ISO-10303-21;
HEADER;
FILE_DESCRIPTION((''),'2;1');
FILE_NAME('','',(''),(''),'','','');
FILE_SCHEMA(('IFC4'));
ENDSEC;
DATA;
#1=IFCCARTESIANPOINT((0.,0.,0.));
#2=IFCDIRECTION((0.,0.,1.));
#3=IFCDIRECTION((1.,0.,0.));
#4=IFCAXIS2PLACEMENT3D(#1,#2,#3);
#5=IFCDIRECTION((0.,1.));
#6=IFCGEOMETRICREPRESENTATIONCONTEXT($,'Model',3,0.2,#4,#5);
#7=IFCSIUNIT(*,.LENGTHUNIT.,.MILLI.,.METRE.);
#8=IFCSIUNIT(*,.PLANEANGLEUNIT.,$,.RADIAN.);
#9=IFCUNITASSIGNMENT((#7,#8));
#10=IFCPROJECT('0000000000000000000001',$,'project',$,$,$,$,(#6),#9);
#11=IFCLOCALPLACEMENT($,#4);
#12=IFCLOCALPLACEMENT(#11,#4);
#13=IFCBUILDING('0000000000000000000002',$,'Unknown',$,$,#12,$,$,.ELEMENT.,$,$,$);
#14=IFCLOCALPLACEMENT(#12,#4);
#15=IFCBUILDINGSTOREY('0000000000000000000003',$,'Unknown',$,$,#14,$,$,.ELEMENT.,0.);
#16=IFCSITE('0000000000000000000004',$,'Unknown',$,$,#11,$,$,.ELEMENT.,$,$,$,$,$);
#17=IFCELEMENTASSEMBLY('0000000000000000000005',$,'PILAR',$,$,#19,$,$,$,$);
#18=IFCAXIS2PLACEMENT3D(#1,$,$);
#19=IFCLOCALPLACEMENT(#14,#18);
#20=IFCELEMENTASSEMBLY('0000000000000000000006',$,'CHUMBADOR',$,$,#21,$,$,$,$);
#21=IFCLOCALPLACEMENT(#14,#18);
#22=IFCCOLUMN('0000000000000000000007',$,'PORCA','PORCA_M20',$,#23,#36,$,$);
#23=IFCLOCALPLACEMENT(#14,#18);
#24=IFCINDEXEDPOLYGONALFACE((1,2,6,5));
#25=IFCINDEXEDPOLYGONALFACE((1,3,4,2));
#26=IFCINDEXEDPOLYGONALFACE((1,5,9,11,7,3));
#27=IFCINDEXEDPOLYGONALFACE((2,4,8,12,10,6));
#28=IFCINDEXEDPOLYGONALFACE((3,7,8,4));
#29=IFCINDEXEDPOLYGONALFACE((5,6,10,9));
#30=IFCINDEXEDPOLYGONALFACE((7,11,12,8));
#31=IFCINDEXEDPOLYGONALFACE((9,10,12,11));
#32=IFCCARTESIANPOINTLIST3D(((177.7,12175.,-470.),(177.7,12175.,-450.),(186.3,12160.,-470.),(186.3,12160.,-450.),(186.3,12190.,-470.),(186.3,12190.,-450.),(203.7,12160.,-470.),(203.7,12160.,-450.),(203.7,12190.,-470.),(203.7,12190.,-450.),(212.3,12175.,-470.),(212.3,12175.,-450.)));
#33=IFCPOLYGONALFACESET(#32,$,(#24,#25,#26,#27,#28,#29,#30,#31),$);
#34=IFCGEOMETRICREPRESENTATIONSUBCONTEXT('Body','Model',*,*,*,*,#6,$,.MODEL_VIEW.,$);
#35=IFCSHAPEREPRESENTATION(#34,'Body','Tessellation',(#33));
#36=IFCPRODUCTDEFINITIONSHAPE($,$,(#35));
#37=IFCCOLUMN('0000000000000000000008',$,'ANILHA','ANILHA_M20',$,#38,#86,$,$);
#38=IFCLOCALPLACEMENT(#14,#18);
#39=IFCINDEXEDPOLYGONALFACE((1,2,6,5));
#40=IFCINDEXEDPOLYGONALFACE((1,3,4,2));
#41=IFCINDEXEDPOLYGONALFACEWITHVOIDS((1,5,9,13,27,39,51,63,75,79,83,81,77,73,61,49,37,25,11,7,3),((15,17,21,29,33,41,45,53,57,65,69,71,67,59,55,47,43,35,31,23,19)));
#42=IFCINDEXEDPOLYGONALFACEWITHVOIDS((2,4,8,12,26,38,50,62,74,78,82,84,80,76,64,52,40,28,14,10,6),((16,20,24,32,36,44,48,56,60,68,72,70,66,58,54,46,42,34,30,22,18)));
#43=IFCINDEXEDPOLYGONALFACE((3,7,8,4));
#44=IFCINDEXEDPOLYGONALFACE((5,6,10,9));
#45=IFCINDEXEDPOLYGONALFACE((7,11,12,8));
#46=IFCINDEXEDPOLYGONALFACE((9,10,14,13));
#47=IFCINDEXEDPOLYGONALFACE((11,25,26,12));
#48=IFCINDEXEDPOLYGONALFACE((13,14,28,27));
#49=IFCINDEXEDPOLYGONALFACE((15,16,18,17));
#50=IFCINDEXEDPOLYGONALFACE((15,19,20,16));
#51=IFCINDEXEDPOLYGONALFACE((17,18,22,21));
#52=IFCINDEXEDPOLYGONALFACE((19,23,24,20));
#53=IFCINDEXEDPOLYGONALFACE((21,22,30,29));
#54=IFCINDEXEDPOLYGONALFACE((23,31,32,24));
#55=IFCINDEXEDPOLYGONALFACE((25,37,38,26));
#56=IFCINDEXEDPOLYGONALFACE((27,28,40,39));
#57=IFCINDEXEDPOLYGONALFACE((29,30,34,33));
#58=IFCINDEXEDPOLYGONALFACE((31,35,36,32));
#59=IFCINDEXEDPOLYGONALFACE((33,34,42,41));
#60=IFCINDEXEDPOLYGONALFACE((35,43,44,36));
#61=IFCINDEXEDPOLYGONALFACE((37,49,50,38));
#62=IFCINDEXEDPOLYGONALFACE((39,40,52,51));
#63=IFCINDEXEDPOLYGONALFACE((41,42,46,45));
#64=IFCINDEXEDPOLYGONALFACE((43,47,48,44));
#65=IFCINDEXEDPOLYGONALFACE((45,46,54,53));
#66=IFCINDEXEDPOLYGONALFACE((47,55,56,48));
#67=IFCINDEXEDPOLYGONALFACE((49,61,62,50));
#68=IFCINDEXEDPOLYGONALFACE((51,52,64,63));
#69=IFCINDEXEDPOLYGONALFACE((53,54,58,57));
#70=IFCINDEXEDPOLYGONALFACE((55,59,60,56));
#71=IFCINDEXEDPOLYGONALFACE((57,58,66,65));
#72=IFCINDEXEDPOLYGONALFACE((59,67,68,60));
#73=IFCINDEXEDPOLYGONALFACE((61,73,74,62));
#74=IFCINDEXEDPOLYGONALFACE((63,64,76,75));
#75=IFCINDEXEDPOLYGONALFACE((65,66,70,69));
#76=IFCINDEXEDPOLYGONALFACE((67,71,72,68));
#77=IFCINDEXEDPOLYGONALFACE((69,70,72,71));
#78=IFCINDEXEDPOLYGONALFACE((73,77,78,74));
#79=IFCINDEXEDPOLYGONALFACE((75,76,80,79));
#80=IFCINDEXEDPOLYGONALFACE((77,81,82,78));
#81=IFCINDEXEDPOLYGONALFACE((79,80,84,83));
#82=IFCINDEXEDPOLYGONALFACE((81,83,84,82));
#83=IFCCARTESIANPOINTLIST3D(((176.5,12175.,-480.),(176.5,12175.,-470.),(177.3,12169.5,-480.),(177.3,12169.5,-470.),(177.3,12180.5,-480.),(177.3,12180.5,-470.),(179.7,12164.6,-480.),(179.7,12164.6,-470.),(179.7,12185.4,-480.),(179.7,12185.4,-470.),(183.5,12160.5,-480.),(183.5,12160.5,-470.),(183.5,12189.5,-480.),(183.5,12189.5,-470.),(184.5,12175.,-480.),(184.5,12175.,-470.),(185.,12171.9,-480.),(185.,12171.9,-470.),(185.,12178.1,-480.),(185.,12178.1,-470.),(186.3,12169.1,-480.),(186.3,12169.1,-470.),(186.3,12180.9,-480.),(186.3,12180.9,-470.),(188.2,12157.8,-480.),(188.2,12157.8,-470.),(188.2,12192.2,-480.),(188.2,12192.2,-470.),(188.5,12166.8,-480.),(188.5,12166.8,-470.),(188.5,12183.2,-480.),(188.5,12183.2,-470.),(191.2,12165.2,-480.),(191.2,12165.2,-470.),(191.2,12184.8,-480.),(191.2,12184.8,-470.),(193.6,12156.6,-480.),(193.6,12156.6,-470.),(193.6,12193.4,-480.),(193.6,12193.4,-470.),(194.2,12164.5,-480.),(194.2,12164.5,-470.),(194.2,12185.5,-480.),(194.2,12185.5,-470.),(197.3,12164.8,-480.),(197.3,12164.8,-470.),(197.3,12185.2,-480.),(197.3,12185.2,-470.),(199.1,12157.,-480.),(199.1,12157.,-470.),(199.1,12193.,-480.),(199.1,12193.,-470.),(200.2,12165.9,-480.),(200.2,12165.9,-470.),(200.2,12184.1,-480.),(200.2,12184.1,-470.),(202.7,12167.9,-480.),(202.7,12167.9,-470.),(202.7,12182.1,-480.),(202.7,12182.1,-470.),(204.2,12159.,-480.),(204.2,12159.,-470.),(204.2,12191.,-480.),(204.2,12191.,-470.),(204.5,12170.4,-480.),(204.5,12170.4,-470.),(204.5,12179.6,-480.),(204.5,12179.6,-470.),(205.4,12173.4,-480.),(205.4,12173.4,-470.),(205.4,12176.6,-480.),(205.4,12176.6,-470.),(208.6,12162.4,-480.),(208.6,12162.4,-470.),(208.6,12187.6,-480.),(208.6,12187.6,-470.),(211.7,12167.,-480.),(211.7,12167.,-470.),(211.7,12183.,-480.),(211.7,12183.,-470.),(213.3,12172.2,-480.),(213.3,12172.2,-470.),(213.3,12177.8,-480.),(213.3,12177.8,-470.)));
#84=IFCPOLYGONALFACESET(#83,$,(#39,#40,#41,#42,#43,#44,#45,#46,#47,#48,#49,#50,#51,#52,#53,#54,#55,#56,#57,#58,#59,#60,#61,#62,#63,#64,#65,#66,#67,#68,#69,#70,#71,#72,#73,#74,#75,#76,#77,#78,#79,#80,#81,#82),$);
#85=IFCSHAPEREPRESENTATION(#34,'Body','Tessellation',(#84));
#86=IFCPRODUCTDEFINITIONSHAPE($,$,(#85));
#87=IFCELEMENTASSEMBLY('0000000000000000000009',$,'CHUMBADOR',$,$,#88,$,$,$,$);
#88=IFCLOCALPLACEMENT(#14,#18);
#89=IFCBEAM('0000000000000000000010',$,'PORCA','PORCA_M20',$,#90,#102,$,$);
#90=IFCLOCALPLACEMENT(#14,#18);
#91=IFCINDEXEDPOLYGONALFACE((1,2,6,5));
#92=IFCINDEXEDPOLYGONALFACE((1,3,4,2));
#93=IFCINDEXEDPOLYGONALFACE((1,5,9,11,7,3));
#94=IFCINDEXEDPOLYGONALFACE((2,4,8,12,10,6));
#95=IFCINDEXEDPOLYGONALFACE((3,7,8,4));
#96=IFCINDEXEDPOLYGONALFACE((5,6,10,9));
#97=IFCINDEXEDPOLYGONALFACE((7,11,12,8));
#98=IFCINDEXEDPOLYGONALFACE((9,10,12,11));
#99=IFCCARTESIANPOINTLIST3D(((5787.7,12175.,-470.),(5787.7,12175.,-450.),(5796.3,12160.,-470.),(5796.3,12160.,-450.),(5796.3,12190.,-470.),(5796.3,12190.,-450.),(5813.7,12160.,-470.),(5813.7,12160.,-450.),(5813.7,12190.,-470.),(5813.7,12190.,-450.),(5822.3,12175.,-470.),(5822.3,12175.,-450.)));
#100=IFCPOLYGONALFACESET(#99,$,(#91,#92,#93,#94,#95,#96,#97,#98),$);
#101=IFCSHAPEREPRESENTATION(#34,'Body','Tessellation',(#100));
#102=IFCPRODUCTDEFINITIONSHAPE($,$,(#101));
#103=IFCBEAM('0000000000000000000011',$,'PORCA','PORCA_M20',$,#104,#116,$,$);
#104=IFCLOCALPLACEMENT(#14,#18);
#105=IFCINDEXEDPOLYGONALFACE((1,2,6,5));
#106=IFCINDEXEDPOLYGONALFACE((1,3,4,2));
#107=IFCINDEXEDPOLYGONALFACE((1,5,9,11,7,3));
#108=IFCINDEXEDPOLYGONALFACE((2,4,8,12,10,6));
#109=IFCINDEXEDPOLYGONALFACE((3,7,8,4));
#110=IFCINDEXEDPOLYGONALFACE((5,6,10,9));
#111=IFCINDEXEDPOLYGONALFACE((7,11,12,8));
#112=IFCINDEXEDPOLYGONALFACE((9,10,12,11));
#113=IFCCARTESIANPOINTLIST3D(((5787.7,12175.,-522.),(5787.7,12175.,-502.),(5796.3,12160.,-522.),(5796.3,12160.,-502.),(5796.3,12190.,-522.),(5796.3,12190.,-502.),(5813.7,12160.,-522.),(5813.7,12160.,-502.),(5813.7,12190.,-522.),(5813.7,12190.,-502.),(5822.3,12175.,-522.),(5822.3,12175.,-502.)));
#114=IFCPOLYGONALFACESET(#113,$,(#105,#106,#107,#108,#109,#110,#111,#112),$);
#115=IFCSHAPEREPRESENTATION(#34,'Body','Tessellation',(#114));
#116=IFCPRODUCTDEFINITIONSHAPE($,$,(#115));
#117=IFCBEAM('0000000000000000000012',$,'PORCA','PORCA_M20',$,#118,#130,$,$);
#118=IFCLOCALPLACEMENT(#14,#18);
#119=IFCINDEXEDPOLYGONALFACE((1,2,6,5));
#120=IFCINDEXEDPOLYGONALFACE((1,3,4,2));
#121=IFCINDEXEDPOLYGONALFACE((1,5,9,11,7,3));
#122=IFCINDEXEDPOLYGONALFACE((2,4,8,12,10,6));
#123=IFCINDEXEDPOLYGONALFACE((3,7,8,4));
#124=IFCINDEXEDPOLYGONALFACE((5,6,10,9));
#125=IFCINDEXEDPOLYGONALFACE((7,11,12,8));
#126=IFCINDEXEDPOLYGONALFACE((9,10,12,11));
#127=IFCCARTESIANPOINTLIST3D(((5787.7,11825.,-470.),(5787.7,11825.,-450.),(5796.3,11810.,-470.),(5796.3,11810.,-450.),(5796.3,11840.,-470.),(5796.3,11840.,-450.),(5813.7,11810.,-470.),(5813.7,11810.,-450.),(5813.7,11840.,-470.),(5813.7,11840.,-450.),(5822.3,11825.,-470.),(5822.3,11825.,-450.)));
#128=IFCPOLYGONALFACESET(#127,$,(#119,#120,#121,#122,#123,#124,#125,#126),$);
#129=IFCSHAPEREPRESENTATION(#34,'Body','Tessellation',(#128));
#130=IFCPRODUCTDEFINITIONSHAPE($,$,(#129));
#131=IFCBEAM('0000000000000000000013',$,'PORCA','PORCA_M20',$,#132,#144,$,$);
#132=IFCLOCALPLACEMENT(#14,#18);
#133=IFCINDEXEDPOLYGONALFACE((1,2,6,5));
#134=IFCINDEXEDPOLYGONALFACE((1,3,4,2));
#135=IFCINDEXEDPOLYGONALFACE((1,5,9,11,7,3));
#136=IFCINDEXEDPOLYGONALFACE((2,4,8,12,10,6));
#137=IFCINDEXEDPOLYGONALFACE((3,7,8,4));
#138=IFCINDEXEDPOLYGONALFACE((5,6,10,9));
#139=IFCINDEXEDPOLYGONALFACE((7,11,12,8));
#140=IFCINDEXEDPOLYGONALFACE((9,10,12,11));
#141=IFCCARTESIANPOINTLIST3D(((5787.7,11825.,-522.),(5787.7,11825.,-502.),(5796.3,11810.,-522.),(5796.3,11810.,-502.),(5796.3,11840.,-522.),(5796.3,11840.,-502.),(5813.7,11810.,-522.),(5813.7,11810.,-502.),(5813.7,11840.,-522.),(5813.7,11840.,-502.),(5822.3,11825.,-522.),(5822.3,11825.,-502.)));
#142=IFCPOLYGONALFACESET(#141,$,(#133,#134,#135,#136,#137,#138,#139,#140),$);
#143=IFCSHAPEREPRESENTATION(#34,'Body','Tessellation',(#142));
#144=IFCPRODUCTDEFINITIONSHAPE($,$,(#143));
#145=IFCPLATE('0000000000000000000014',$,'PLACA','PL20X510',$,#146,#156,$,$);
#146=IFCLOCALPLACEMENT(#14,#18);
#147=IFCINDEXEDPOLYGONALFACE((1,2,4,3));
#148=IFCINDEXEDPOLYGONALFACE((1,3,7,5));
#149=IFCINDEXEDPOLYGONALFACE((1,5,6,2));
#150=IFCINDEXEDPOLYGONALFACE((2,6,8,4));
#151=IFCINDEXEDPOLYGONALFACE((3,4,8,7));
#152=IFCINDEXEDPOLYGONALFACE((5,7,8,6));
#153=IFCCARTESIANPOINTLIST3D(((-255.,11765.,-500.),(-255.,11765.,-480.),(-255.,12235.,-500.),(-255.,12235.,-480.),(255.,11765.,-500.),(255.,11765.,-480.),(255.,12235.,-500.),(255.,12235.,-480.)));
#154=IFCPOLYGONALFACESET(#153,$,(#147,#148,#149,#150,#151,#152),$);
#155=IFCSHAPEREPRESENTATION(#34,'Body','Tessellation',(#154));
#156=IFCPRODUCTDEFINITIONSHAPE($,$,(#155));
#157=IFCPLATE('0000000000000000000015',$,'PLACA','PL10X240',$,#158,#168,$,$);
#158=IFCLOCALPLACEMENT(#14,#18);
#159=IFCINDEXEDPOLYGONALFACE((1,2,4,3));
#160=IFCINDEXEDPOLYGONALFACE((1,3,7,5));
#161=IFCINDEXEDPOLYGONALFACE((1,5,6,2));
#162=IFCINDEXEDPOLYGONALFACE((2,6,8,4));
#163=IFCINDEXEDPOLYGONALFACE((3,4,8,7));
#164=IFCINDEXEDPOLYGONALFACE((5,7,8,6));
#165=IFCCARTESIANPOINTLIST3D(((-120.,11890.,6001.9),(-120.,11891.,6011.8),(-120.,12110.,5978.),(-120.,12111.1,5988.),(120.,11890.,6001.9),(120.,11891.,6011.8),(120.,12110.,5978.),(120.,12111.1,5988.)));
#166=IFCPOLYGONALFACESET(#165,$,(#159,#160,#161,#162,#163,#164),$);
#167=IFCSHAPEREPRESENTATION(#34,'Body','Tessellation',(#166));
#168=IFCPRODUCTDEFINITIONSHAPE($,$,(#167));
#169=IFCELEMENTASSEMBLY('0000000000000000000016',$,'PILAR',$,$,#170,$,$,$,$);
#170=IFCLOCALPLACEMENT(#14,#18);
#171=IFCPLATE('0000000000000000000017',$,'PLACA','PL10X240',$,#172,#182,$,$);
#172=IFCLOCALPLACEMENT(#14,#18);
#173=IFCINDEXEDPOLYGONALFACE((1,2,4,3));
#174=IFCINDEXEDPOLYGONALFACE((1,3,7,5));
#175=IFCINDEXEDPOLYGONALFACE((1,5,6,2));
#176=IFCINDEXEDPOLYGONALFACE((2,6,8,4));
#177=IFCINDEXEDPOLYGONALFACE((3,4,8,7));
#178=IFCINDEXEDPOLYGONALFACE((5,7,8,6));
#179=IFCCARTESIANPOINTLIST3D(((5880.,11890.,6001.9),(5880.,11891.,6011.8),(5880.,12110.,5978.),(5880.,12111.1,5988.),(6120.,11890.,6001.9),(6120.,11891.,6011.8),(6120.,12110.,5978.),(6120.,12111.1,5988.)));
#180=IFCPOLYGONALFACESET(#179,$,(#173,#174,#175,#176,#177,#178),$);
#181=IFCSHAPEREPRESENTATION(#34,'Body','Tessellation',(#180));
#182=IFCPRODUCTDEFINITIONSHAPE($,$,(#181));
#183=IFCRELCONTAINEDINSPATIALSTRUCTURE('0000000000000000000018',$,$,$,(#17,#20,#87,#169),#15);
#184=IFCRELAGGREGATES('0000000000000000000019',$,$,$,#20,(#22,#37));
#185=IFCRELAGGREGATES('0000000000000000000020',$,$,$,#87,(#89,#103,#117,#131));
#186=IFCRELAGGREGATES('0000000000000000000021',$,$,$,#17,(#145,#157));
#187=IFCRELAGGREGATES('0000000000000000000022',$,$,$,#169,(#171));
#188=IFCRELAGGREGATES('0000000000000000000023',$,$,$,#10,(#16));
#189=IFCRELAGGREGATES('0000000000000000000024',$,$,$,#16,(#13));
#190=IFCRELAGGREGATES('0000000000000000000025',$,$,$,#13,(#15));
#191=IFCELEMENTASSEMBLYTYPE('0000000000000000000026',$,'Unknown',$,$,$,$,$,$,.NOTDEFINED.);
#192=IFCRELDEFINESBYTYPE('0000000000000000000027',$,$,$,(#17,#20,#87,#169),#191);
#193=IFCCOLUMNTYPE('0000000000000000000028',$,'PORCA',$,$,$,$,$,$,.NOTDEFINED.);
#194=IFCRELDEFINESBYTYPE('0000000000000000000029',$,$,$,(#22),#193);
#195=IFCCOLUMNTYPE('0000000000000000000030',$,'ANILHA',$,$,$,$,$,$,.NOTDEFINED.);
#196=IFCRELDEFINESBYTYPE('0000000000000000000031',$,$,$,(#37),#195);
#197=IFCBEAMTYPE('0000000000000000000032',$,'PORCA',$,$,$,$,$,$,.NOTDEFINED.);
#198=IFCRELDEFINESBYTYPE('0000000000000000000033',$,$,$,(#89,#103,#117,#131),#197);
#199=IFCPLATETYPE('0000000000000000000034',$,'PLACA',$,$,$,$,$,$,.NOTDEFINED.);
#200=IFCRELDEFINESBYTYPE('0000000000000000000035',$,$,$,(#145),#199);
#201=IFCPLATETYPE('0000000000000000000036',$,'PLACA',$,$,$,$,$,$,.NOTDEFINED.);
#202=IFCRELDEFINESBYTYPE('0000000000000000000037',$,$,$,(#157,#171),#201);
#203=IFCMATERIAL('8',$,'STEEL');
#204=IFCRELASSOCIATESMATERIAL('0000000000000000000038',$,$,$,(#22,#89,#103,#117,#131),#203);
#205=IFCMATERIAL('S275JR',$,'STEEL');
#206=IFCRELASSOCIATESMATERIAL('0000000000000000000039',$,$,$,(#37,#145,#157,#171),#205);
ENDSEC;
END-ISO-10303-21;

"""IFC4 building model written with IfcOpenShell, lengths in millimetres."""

from ifc_helpers import new_model, si_unit, direction, frame, origin_with_axes, origin_2d_with_axis, place, context, subcontext, project, spatial, polyline, rectangle, hollow_circle, outline, extrude, material, material_profile, profile_set, profile_usage, type_object, element, aggregate, save


model = new_model("IFC4")

# Units and contexts
model_context = context("Model", 3, precision=0.2, world=origin_with_axes(), true_north=direction((0.0, 1.0)))
body_context = subcontext(model_context, "Body", "Model", "MODEL_VIEW")
ifc_project = project(units=[si_unit("LENGTHUNIT", "METRE", prefix="MILLI"), si_unit("PLANEANGLEUNIT", "RADIAN")], contexts=[model_context])

# Site, building, storey
site_placement = place(None, origin_with_axes())
site = spatial("IfcSite", under=ifc_project, at=site_placement, Name="Unknown", CompositionType="ELEMENT")
building_placement = place(site_placement, origin_with_axes())
building = spatial("IfcBuilding", under=site, at=building_placement, Name="Unknown", CompositionType="ELEMENT")
storey_placement = place(building_placement, origin_with_axes())
storey = spatial("IfcBuildingStorey", under=building, at=storey_placement, Name="Unknown", CompositionType="ELEMENT", Elevation=0.0)

# Shared definitions
element_assembly_type = type_object("IfcElementAssemblyType", Name="Unknown", PredefinedType="NOTDEFINED")

# Element assembly
assembly_1_placement = place(storey_placement, frame((0.0, 12000.0, -500.0), z_axis=(-1.0, 0.0, 0.0), x_axis=(0.0, 0.0, 1.0)))
assembly_1 = element("IfcElementAssembly", 1, at=assembly_1_placement, inside=storey, type_object=element_assembly_type, Name="PILAR")

# Element assembly, columns
assembly_2_placement = place(storey_placement, frame((195.0, 12175.0, -555.0), z_axis=(-1.0, 0.0, 0.0), x_axis=(0.0, 0.0, -1.0)))
assembly_2 = element("IfcElementAssembly", 2, at=assembly_2_placement, inside=storey, type_object=element_assembly_type, Name="CHUMBADOR")
ifc_material_1 = material(Name="8", Category="STEEL")
ifc_material_profile_1 = material_profile(ifc_material_1, outline(polyline([(8.7, -15.0), (17.3, 0.0), (8.7, 15.0), (-8.7, 15.0), (-17.3, 0.0), (-8.7, -15.0), (8.7, -15.0)])), Name="PORCA_M20")
ifc_profile_set_1 = profile_set([ifc_material_profile_1])
ifc_profile_usage_1 = profile_usage(ifc_profile_set_1, cardinal=5)
column_type_1 = type_object("IfcColumnType", Name="PORCA", PredefinedType="NOTDEFINED")
column_1_placement = place(assembly_2_placement, frame((-105.0, 0.0, 0.0), z_axis=(0.0, 0.0, -1.0), x_axis=(1.0, 0.0, 0.0)))
column_1 = element("IfcColumn", 3, at=column_1_placement, type_object=column_type_1, material=ifc_profile_usage_1, Name="PORCA", Description="PORCA_M20", context=body_context, shape_type="SolidModel", body=[
    extrude(outline(polyline([(8.7, -15.0), (17.3, 0.0), (8.7, 15.0), (-8.7, 15.0), (-17.3, 0.0), (-8.7, -15.0), (8.7, -15.0)])), frame((0.0, 0.0, 0.0), z_axis=(-1.0, 0.0, 0.0), x_axis=(0.0, 0.0, 1.0)), (0.0, 0.0, -1.0), 20.0),
])
ifc_material_2 = material(Name="S275JR", Category="STEEL")
ifc_material_profile_2 = material_profile(ifc_material_2, hollow_circle(Radius=18.5, WallThickness=8.0, at=origin_2d_with_axis()), Name="ANILHA_M20")
ifc_profile_set_2 = profile_set([ifc_material_profile_2])
ifc_profile_usage_2 = profile_usage(ifc_profile_set_2, cardinal=5)
column_type_2 = type_object("IfcColumnType", Name="ANILHA", PredefinedType="NOTDEFINED")
column_2_placement = place(assembly_2_placement, frame((-85.0, 0.0, 0.0), z_axis=(0.0, 0.0, 1.0), x_axis=(1.0, 0.0, 0.0)))
column_2 = element("IfcColumn", 4, at=column_2_placement, type_object=column_type_2, material=ifc_profile_usage_2, Name="ANILHA", Description="ANILHA_M20", context=body_context, shape_type="SolidModel", body=[
    extrude(hollow_circle(Radius=18.5, WallThickness=8.0, at=origin_2d_with_axis()), frame((0.0, 0.0, 0.0), z_axis=(-1.0, 0.0, 0.0), x_axis=(0.0, 0.0, 1.0)), (0.0, 0.0, -1.0), 10.0),
])
aggregate(assembly_2, [column_1, column_2])

# Element assembly, beams
assembly_3_placement = place(storey_placement, frame((6195.0, 12175.0, -555.0), z_axis=(-1.0, 0.0, 0.0), x_axis=(0.0, 0.0, -1.0)))
assembly_3 = element("IfcElementAssembly", 5, at=assembly_3_placement, inside=storey, type_object=element_assembly_type, Name="CHUMBADOR")
beam_type_1 = type_object("IfcBeamType", Name="PORCA", PredefinedType="NOTDEFINED")
beam_1_placement = place(assembly_3_placement, frame((-105.0, 0.0, 390.0), z_axis=(0.0, 0.0, 1.0), x_axis=(1.0, 0.0, 0.0)))
beam_1 = element("IfcBeam", 6, at=beam_1_placement, type_object=beam_type_1, material=ifc_profile_usage_1, Name="PORCA", Description="PORCA_M20", context=body_context, shape_type="SolidModel", body=[
    extrude(outline(polyline([(8.7, -15.0), (17.3, 0.0), (8.7, 15.0), (-8.7, 15.0), (-17.3, 0.0), (-8.7, -15.0), (8.7, -15.0)])), frame((0.0, 0.0, 0.0), z_axis=(-1.0, 0.0, 0.0), x_axis=(0.0, 0.0, 1.0)), (0.0, 0.0, -1.0), 20.0),
])
beam_2_placement = place(assembly_3_placement, frame((-53.0, 0.0, 390.0), z_axis=(0.0, 0.0, 1.0), x_axis=(1.0, 0.0, 0.0)))
beam_2 = element("IfcBeam", 7, at=beam_2_placement, type_object=beam_type_1, material=ifc_profile_usage_1, Name="PORCA", Description="PORCA_M20", context=body_context, shape_type="SolidModel", body=[
    extrude(outline(polyline([(8.7, -15.0), (17.3, 0.0), (8.7, 15.0), (-8.7, 15.0), (-17.3, 0.0), (-8.7, -15.0), (8.7, -15.0)])), frame((0.0, 0.0, 0.0), z_axis=(-1.0, 0.0, 0.0), x_axis=(0.0, 0.0, 1.0)), (0.0, 0.0, -1.0), 20.0),
])
beam_3_placement = place(assembly_3_placement, frame((-105.0, 350.0, 390.0), z_axis=(0.0, 0.0, 1.0), x_axis=(1.0, 0.0, 0.0)))
beam_3 = element("IfcBeam", 8, at=beam_3_placement, type_object=beam_type_1, material=ifc_profile_usage_1, Name="PORCA", Description="PORCA_M20", context=body_context, shape_type="SolidModel", body=[
    extrude(outline(polyline([(8.7, -15.0), (17.3, 0.0), (8.7, 15.0), (-8.7, 15.0), (-17.3, 0.0), (-8.7, -15.0), (8.7, -15.0)])), frame((0.0, 0.0, 0.0), z_axis=(-1.0, 0.0, 0.0), x_axis=(0.0, 0.0, 1.0)), (0.0, 0.0, -1.0), 20.0),
])
beam_4_placement = place(assembly_3_placement, frame((-53.0, 350.0, 390.0), z_axis=(0.0, 0.0, 1.0), x_axis=(1.0, 0.0, 0.0)))
beam_4 = element("IfcBeam", 9, at=beam_4_placement, type_object=beam_type_1, material=ifc_profile_usage_1, Name="PORCA", Description="PORCA_M20", context=body_context, shape_type="SolidModel", body=[
    extrude(outline(polyline([(8.7, -15.0), (17.3, 0.0), (8.7, 15.0), (-8.7, 15.0), (-17.3, 0.0), (-8.7, -15.0), (8.7, -15.0)])), frame((0.0, 0.0, 0.0), z_axis=(-1.0, 0.0, 0.0), x_axis=(0.0, 0.0, 1.0)), (0.0, 0.0, -1.0), 20.0),
])
aggregate(assembly_3, [beam_1, beam_2, beam_3, beam_4])

# Plates
ifc_material_profile_3 = material_profile(ifc_material_2, rectangle(XDim=470.0, YDim=510.0, at=origin_2d_with_axis()), Name="PL20X510")
ifc_profile_set_3 = profile_set([ifc_material_profile_3])
ifc_profile_usage_3 = profile_usage(ifc_profile_set_3, cardinal=8)
plate_type_1 = type_object("IfcPlateType", Name="PLACA", PredefinedType="NOTDEFINED")
plate_1_placement = place(assembly_1_placement, frame((10.0, 235.0, 0.0), z_axis=(0.0, -1.0, 0.0), x_axis=(1.0, 0.0, 0.0)))
plate_1 = element("IfcPlate", 10, at=plate_1_placement, type_object=plate_type_1, material=ifc_profile_usage_3, Name="PLACA", Description="PL20X510", context=body_context, shape_type="SolidModel", body=[
    extrude(rectangle(XDim=470.0, YDim=510.0, at=origin_2d_with_axis()), frame((-10.0, 0.0, 235.0), z_axis=(-1.0, 0.0, 0.0), x_axis=(0.0, 0.0, 1.0)), (0.0, 0.0, -1.0), 20.0),
])
ifc_material_profile_4 = material_profile(ifc_material_2, rectangle(XDim=221.3, YDim=240.0, at=origin_2d_with_axis()), Name="PL10X240")
ifc_profile_set_4 = profile_set([ifc_material_profile_4])
ifc_profile_usage_4 = profile_usage(ifc_profile_set_4, cardinal=2)
plate_type_2 = type_object("IfcPlateType", Name="PLACA", PredefinedType="NOTDEFINED")
plate_2_placement = place(assembly_1_placement, frame((6506.8, -109.5, 0.0), z_axis=(-0.107703, 0.994183, 0.0), x_axis=(-0.994183, -0.107703, 0.0)))
plate_2 = element("IfcPlate", 11, at=plate_2_placement, type_object=plate_type_2, material=ifc_profile_usage_4, Name="PLACA", Description="PL10X240", context=body_context, shape_type="SolidModel", body=[
    extrude(rectangle(XDim=221.3, YDim=240.0, at=origin_2d_with_axis()), frame((-5.0, 0.0, 110.7), z_axis=(-1.0, 0.0, 0.0), x_axis=(0.0, 0.0, 1.0)), (0.0, 0.0, -1.0), 10.0),
])
aggregate(assembly_1, [plate_1, plate_2])

# Element assembly, plate
assembly_4_placement = place(storey_placement, frame((6000.0, 12000.0, -500.0), z_axis=(-1.0, 0.0, 0.0), x_axis=(0.0, 0.0, 1.0)))
assembly_4 = element("IfcElementAssembly", 12, at=assembly_4_placement, inside=storey, type_object=element_assembly_type, Name="PILAR")
plate_3_placement = place(assembly_4_placement, frame((6506.8, -109.5, 0.0), z_axis=(-0.107703, 0.994183, 0.0), x_axis=(-0.994183, -0.107703, 0.0)))
plate_3 = element("IfcPlate", 13, at=plate_3_placement, type_object=plate_type_2, material=ifc_profile_usage_4, Name="PLACA", Description="PL10X240", context=body_context, shape_type="SolidModel", body=[
    extrude(rectangle(XDim=221.3, YDim=240.0, at=origin_2d_with_axis()), frame((-5.0, 0.0, 110.7), z_axis=(-1.0, 0.0, 0.0), x_axis=(0.0, 0.0, 1.0)), (0.0, 0.0, -1.0), 10.0),
])
aggregate(assembly_4, [plate_3])

save(model, "model.ifc")
